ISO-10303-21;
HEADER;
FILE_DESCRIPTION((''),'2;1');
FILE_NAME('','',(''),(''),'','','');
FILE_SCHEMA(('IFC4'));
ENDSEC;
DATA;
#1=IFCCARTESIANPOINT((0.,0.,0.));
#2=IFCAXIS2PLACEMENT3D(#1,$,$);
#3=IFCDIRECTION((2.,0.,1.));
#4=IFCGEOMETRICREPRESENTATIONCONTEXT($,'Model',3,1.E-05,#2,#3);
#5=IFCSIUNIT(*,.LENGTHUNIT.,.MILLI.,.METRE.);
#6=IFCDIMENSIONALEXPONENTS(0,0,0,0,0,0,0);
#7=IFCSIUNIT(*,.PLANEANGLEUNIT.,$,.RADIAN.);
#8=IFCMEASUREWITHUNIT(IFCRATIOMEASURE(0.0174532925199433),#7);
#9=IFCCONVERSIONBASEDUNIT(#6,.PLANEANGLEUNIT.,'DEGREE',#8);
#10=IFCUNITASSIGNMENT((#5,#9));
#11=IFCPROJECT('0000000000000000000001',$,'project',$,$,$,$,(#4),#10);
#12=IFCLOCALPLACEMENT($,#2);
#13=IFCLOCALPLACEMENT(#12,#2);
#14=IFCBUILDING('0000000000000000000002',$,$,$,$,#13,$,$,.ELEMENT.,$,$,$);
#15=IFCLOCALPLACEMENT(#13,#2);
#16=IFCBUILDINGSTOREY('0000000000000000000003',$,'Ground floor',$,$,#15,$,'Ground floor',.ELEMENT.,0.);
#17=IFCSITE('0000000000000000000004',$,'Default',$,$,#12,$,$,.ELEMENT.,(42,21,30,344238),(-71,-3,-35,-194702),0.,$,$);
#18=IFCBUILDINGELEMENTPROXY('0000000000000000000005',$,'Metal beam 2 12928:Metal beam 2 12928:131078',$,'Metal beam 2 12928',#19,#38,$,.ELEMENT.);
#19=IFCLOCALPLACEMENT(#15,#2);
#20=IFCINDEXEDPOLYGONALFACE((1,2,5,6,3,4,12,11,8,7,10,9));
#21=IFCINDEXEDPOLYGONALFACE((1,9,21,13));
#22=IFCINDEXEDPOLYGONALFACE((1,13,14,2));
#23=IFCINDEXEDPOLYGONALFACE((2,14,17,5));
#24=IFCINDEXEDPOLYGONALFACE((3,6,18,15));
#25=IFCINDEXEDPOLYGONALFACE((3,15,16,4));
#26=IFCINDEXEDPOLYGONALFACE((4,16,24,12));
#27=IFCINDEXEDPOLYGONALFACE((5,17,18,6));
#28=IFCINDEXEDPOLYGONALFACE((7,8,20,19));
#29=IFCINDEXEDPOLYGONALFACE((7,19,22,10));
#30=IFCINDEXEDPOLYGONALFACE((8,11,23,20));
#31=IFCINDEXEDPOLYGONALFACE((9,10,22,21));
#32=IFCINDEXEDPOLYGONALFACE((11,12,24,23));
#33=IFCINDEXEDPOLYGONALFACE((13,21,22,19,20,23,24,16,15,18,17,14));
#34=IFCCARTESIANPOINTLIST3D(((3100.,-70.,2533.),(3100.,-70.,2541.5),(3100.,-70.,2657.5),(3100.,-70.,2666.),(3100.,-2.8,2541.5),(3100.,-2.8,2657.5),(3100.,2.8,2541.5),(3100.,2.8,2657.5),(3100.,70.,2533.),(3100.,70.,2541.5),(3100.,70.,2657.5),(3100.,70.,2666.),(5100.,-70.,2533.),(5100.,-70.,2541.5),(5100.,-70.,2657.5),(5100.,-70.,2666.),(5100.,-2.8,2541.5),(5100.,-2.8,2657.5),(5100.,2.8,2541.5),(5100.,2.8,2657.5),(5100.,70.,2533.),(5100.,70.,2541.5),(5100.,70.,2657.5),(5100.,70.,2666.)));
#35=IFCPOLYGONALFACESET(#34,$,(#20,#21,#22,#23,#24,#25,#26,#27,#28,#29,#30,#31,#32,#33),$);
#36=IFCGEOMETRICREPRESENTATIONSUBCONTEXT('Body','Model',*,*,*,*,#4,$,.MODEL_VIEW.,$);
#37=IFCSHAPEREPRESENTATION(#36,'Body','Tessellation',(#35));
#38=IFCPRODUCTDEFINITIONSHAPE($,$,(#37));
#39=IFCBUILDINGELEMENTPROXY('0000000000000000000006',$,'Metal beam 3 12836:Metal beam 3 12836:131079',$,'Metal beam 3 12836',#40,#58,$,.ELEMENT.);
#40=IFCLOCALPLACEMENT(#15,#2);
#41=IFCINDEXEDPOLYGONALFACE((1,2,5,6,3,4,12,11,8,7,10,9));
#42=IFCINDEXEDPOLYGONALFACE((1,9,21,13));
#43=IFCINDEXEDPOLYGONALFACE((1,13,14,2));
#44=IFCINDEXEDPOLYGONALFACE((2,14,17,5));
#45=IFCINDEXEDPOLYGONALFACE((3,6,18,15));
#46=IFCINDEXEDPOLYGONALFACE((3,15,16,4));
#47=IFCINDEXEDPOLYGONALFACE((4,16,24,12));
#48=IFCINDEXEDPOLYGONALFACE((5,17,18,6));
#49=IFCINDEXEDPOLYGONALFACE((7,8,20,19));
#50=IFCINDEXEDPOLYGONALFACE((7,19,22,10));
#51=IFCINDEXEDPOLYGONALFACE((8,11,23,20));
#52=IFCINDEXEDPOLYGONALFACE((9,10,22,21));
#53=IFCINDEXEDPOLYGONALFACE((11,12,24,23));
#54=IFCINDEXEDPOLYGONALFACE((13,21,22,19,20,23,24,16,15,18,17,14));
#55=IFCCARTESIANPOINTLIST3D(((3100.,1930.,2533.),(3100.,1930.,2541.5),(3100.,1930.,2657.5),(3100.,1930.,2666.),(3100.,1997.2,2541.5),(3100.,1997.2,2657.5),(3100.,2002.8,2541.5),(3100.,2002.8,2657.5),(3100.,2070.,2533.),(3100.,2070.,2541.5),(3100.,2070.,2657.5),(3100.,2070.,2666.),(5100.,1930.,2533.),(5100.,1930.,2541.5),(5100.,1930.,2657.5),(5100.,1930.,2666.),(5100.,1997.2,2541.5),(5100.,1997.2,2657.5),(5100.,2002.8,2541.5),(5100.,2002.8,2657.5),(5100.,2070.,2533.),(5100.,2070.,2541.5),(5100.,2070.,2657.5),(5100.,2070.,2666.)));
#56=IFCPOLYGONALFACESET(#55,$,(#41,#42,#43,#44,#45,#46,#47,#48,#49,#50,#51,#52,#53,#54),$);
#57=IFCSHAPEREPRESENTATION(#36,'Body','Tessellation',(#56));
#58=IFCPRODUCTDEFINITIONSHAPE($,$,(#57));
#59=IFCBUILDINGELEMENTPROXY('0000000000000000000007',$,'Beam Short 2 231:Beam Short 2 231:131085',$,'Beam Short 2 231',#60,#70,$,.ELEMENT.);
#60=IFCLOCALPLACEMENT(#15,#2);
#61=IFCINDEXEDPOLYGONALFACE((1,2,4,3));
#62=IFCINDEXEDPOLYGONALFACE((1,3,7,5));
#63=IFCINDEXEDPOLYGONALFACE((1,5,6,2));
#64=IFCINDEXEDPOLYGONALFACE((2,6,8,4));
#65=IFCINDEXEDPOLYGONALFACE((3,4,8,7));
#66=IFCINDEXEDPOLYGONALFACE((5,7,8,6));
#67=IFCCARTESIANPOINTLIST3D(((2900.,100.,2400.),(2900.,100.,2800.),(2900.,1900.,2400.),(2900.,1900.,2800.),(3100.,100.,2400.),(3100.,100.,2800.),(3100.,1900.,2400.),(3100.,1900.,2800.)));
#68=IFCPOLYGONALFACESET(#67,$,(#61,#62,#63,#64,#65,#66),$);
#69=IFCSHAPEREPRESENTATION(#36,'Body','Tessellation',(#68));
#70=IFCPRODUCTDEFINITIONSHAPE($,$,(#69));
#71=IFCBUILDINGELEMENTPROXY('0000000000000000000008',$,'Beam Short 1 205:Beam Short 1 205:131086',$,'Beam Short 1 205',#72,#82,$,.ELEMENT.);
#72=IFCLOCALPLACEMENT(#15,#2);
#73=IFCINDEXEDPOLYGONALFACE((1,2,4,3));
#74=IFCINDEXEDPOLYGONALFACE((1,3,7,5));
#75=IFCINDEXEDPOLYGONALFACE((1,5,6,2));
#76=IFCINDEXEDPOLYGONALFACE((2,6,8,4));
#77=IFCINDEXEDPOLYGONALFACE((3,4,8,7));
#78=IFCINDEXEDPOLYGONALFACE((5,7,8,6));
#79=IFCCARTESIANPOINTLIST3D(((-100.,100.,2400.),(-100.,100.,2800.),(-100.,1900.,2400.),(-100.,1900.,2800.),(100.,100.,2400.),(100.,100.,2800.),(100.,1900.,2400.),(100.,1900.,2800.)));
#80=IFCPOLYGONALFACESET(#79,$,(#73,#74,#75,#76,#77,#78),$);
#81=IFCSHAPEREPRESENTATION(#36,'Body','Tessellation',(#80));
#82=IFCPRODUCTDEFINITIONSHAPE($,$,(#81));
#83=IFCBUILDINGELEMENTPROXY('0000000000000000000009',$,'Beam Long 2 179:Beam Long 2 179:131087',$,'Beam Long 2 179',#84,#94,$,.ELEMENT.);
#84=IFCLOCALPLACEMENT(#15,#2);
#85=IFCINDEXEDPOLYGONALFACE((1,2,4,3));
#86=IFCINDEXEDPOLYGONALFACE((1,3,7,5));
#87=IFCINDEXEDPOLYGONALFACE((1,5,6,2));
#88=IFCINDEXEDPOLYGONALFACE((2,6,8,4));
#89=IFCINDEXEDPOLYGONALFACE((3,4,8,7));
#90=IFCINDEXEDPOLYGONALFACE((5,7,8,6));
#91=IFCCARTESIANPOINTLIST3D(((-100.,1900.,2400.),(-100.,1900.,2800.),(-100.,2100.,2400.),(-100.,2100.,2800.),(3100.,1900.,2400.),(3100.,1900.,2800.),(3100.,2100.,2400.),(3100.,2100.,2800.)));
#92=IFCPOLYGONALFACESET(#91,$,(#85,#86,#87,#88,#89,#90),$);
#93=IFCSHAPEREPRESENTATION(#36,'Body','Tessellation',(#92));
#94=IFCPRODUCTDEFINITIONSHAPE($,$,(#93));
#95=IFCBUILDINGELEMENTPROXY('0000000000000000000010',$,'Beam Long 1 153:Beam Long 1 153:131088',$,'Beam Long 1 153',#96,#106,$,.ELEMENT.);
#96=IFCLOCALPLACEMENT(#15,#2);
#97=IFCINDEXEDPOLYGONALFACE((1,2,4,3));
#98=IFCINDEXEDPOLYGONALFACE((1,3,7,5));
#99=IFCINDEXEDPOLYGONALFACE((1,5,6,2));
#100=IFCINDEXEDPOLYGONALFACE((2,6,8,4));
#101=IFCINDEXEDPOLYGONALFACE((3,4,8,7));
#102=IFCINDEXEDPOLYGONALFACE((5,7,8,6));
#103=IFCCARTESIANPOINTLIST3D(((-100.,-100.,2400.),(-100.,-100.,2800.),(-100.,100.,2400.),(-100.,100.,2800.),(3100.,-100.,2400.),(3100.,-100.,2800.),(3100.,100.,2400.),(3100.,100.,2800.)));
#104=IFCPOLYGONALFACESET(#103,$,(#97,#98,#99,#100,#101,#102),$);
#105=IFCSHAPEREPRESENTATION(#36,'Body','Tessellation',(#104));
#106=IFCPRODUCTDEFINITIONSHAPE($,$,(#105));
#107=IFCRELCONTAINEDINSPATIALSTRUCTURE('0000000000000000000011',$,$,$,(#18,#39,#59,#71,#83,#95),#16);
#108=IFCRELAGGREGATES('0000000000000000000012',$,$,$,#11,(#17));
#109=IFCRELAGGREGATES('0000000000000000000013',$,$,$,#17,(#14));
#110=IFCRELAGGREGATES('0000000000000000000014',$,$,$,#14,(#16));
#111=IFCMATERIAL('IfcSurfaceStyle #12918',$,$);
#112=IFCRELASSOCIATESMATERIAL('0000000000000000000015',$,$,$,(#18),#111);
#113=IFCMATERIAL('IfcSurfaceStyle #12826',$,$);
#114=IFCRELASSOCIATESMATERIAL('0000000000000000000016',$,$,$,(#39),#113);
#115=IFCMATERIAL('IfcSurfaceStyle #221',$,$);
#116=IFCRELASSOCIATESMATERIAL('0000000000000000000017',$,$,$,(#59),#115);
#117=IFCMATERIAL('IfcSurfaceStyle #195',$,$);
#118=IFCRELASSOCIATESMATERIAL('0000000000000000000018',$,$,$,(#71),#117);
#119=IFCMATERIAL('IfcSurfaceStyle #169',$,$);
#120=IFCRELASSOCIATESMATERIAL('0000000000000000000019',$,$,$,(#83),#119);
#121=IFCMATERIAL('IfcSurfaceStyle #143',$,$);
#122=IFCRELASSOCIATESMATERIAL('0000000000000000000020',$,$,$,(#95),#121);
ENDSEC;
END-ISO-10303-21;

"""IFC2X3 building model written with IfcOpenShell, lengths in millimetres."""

from ifc_helpers import new_model, entity, si_unit, converted_unit, direction, frame, frame_2d, origin, origin_2d_with_axis, place, context, subcontext, project, spatial, rectangle, i_section, extrude, source, transform, mapped, material, element, save


model = new_model("IFC2X3")

# Units and contexts
model_context = context("Model", 3, precision=1e-05, world=origin(), true_north=direction((2.0, 0.0, 1.0)))
body_context = subcontext(model_context, "Body", "Model", "MODEL_VIEW")
ifc_project = project(units=[si_unit("LENGTHUNIT", "METRE", prefix="MILLI"), converted_unit("PLANEANGLEUNIT", "DEGREE", entity("IfcRatioMeasure", 0.0174532925199433), si_unit("PLANEANGLEUNIT", "RADIAN"), dimensions=[0, 0, 0, 0, 0, 0, 0])], contexts=[model_context])

# Site, building, storey
site_placement = place(None, origin())
site = spatial("IfcSite", under=ifc_project, at=site_placement, Name="Default", CompositionType="ELEMENT", RefLatitude=(42, 21, 30, 344238), RefLongitude=(-71, -3, -35, -194702), RefElevation=0.0)
building_placement = place(site_placement, origin())
building = spatial("IfcBuilding", under=site, at=building_placement, CompositionType="ELEMENT")
storey_placement = place(building_placement, origin())
storey = spatial("IfcBuildingStorey", under=building, at=storey_placement, Name="Ground floor", LongName="Ground floor", CompositionType="ELEMENT", Elevation=0.0)

# Building element proxies
ifc_material_1 = material(Name="IfcSurfaceStyle #12918")
shared_shape_1 = source(origin(), body_context, "Body", "SweptSolid", [
    extrude(i_section(OverallWidth=140.0, OverallDepth=133.0, WebThickness=5.5, FlangeThickness=8.5, at=frame_2d((0.0, 0.0), x_axis=(1.0, 0.0))), frame((3100.0, 0.0, 2599.5), z_axis=(1.0, 0.0, 0.0), x_axis=(0.0, 1.0, 0.0)), (0.0, 0.0, 1.0), 2000.0),
])
proxy_1_placement = place(storey_placement, origin())
element("IfcBuildingElementProxy", 1, at=proxy_1_placement, inside=storey, material=ifc_material_1, Name="Metal beam 2 12928:Metal beam 2 12928:131078", ObjectType="Metal beam 2 12928", CompositionType="ELEMENT", context=body_context, shape_type="MappedRepresentation", body=[
    mapped(shared_shape_1, transform((0.0, 0.0, 0.0), scale=1.0)),
])
ifc_material_2 = material(Name="IfcSurfaceStyle #12826")
shared_shape_2 = source(origin(), body_context, "Body", "SweptSolid", [
    extrude(i_section(OverallWidth=140.0, OverallDepth=133.0, WebThickness=5.5, FlangeThickness=8.5, at=frame_2d((0.0, 0.0), x_axis=(1.0, 0.0))), frame((3100.0, 2000.0, 2599.5), z_axis=(1.0, 0.0, 0.0), x_axis=(0.0, 1.0, 0.0)), (0.0, 0.0, 1.0), 2000.0),
])
proxy_2_placement = place(storey_placement, origin())
element("IfcBuildingElementProxy", 2, at=proxy_2_placement, inside=storey, material=ifc_material_2, Name="Metal beam 3 12836:Metal beam 3 12836:131079", ObjectType="Metal beam 3 12836", CompositionType="ELEMENT", context=body_context, shape_type="MappedRepresentation", body=[
    mapped(shared_shape_2, transform((0.0, 0.0, 0.0), scale=1.0)),
])
ifc_material_3 = material(Name="IfcSurfaceStyle #221")
shared_shape_3 = source(origin(), body_context, "Body", "SweptSolid", [
    extrude(rectangle(XDim=1800.0, YDim=200.0, at=origin_2d_with_axis()), frame((3000.0, 1000.0, 2400.0), z_axis=(0.0, 0.0, 1.0), x_axis=(0.0, -1.0, 0.0)), (0.0, 0.0, 1.0), 400.0),
])
proxy_3_placement = place(storey_placement, origin())
element("IfcBuildingElementProxy", 3, at=proxy_3_placement, inside=storey, material=ifc_material_3, Name="Beam Short 2 231:Beam Short 2 231:131085", ObjectType="Beam Short 2 231", CompositionType="ELEMENT", context=body_context, shape_type="MappedRepresentation", body=[
    mapped(shared_shape_3, transform((0.0, 0.0, 0.0), scale=1.0)),
])
ifc_material_4 = material(Name="IfcSurfaceStyle #195")
shared_shape_4 = source(origin(), body_context, "Body", "SweptSolid", [
    extrude(rectangle(XDim=1800.0, YDim=200.0, at=origin_2d_with_axis()), frame((0.0, 1000.0, 2400.0), z_axis=(0.0, 0.0, 1.0), x_axis=(0.0, -1.0, 0.0)), (0.0, 0.0, 1.0), 400.0),
])
proxy_4_placement = place(storey_placement, origin())
element("IfcBuildingElementProxy", 4, at=proxy_4_placement, inside=storey, material=ifc_material_4, Name="Beam Short 1 205:Beam Short 1 205:131086", ObjectType="Beam Short 1 205", CompositionType="ELEMENT", context=body_context, shape_type="MappedRepresentation", body=[
    mapped(shared_shape_4, transform((0.0, 0.0, 0.0), scale=1.0)),
])
ifc_material_5 = material(Name="IfcSurfaceStyle #169")
shared_shape_5 = source(origin(), body_context, "Body", "SweptSolid", [
    extrude(rectangle(XDim=3200.0, YDim=200.0, at=origin_2d_with_axis()), frame((1500.0, 2000.0, 2400.0), z_axis=(0.0, 0.0, 1.0), x_axis=(-1.0, 0.0, 0.0)), (0.0, 0.0, 1.0), 400.0),
])
proxy_5_placement = place(storey_placement, origin())
element("IfcBuildingElementProxy", 5, at=proxy_5_placement, inside=storey, material=ifc_material_5, Name="Beam Long 2 179:Beam Long 2 179:131087", ObjectType="Beam Long 2 179", CompositionType="ELEMENT", context=body_context, shape_type="MappedRepresentation", body=[
    mapped(shared_shape_5, transform((0.0, 0.0, 0.0), scale=1.0)),
])
ifc_material_6 = material(Name="IfcSurfaceStyle #143")
shared_shape_6 = source(origin(), body_context, "Body", "SweptSolid", [
    extrude(rectangle(XDim=3200.0, YDim=200.0, at=origin_2d_with_axis()), frame((1500.0, 0.0, 2400.0), z_axis=(0.0, 0.0, 1.0), x_axis=(-1.0, 0.0, 0.0)), (0.0, 0.0, 1.0), 400.0),
])
proxy_6_placement = place(storey_placement, origin())
element("IfcBuildingElementProxy", 6, at=proxy_6_placement, inside=storey, material=ifc_material_6, Name="Beam Long 1 153:Beam Long 1 153:131088", ObjectType="Beam Long 1 153", CompositionType="ELEMENT", context=body_context, shape_type="MappedRepresentation", body=[
    mapped(shared_shape_6, transform((0.0, 0.0, 0.0), scale=1.0)),
])

save(model, "model.ifc")
